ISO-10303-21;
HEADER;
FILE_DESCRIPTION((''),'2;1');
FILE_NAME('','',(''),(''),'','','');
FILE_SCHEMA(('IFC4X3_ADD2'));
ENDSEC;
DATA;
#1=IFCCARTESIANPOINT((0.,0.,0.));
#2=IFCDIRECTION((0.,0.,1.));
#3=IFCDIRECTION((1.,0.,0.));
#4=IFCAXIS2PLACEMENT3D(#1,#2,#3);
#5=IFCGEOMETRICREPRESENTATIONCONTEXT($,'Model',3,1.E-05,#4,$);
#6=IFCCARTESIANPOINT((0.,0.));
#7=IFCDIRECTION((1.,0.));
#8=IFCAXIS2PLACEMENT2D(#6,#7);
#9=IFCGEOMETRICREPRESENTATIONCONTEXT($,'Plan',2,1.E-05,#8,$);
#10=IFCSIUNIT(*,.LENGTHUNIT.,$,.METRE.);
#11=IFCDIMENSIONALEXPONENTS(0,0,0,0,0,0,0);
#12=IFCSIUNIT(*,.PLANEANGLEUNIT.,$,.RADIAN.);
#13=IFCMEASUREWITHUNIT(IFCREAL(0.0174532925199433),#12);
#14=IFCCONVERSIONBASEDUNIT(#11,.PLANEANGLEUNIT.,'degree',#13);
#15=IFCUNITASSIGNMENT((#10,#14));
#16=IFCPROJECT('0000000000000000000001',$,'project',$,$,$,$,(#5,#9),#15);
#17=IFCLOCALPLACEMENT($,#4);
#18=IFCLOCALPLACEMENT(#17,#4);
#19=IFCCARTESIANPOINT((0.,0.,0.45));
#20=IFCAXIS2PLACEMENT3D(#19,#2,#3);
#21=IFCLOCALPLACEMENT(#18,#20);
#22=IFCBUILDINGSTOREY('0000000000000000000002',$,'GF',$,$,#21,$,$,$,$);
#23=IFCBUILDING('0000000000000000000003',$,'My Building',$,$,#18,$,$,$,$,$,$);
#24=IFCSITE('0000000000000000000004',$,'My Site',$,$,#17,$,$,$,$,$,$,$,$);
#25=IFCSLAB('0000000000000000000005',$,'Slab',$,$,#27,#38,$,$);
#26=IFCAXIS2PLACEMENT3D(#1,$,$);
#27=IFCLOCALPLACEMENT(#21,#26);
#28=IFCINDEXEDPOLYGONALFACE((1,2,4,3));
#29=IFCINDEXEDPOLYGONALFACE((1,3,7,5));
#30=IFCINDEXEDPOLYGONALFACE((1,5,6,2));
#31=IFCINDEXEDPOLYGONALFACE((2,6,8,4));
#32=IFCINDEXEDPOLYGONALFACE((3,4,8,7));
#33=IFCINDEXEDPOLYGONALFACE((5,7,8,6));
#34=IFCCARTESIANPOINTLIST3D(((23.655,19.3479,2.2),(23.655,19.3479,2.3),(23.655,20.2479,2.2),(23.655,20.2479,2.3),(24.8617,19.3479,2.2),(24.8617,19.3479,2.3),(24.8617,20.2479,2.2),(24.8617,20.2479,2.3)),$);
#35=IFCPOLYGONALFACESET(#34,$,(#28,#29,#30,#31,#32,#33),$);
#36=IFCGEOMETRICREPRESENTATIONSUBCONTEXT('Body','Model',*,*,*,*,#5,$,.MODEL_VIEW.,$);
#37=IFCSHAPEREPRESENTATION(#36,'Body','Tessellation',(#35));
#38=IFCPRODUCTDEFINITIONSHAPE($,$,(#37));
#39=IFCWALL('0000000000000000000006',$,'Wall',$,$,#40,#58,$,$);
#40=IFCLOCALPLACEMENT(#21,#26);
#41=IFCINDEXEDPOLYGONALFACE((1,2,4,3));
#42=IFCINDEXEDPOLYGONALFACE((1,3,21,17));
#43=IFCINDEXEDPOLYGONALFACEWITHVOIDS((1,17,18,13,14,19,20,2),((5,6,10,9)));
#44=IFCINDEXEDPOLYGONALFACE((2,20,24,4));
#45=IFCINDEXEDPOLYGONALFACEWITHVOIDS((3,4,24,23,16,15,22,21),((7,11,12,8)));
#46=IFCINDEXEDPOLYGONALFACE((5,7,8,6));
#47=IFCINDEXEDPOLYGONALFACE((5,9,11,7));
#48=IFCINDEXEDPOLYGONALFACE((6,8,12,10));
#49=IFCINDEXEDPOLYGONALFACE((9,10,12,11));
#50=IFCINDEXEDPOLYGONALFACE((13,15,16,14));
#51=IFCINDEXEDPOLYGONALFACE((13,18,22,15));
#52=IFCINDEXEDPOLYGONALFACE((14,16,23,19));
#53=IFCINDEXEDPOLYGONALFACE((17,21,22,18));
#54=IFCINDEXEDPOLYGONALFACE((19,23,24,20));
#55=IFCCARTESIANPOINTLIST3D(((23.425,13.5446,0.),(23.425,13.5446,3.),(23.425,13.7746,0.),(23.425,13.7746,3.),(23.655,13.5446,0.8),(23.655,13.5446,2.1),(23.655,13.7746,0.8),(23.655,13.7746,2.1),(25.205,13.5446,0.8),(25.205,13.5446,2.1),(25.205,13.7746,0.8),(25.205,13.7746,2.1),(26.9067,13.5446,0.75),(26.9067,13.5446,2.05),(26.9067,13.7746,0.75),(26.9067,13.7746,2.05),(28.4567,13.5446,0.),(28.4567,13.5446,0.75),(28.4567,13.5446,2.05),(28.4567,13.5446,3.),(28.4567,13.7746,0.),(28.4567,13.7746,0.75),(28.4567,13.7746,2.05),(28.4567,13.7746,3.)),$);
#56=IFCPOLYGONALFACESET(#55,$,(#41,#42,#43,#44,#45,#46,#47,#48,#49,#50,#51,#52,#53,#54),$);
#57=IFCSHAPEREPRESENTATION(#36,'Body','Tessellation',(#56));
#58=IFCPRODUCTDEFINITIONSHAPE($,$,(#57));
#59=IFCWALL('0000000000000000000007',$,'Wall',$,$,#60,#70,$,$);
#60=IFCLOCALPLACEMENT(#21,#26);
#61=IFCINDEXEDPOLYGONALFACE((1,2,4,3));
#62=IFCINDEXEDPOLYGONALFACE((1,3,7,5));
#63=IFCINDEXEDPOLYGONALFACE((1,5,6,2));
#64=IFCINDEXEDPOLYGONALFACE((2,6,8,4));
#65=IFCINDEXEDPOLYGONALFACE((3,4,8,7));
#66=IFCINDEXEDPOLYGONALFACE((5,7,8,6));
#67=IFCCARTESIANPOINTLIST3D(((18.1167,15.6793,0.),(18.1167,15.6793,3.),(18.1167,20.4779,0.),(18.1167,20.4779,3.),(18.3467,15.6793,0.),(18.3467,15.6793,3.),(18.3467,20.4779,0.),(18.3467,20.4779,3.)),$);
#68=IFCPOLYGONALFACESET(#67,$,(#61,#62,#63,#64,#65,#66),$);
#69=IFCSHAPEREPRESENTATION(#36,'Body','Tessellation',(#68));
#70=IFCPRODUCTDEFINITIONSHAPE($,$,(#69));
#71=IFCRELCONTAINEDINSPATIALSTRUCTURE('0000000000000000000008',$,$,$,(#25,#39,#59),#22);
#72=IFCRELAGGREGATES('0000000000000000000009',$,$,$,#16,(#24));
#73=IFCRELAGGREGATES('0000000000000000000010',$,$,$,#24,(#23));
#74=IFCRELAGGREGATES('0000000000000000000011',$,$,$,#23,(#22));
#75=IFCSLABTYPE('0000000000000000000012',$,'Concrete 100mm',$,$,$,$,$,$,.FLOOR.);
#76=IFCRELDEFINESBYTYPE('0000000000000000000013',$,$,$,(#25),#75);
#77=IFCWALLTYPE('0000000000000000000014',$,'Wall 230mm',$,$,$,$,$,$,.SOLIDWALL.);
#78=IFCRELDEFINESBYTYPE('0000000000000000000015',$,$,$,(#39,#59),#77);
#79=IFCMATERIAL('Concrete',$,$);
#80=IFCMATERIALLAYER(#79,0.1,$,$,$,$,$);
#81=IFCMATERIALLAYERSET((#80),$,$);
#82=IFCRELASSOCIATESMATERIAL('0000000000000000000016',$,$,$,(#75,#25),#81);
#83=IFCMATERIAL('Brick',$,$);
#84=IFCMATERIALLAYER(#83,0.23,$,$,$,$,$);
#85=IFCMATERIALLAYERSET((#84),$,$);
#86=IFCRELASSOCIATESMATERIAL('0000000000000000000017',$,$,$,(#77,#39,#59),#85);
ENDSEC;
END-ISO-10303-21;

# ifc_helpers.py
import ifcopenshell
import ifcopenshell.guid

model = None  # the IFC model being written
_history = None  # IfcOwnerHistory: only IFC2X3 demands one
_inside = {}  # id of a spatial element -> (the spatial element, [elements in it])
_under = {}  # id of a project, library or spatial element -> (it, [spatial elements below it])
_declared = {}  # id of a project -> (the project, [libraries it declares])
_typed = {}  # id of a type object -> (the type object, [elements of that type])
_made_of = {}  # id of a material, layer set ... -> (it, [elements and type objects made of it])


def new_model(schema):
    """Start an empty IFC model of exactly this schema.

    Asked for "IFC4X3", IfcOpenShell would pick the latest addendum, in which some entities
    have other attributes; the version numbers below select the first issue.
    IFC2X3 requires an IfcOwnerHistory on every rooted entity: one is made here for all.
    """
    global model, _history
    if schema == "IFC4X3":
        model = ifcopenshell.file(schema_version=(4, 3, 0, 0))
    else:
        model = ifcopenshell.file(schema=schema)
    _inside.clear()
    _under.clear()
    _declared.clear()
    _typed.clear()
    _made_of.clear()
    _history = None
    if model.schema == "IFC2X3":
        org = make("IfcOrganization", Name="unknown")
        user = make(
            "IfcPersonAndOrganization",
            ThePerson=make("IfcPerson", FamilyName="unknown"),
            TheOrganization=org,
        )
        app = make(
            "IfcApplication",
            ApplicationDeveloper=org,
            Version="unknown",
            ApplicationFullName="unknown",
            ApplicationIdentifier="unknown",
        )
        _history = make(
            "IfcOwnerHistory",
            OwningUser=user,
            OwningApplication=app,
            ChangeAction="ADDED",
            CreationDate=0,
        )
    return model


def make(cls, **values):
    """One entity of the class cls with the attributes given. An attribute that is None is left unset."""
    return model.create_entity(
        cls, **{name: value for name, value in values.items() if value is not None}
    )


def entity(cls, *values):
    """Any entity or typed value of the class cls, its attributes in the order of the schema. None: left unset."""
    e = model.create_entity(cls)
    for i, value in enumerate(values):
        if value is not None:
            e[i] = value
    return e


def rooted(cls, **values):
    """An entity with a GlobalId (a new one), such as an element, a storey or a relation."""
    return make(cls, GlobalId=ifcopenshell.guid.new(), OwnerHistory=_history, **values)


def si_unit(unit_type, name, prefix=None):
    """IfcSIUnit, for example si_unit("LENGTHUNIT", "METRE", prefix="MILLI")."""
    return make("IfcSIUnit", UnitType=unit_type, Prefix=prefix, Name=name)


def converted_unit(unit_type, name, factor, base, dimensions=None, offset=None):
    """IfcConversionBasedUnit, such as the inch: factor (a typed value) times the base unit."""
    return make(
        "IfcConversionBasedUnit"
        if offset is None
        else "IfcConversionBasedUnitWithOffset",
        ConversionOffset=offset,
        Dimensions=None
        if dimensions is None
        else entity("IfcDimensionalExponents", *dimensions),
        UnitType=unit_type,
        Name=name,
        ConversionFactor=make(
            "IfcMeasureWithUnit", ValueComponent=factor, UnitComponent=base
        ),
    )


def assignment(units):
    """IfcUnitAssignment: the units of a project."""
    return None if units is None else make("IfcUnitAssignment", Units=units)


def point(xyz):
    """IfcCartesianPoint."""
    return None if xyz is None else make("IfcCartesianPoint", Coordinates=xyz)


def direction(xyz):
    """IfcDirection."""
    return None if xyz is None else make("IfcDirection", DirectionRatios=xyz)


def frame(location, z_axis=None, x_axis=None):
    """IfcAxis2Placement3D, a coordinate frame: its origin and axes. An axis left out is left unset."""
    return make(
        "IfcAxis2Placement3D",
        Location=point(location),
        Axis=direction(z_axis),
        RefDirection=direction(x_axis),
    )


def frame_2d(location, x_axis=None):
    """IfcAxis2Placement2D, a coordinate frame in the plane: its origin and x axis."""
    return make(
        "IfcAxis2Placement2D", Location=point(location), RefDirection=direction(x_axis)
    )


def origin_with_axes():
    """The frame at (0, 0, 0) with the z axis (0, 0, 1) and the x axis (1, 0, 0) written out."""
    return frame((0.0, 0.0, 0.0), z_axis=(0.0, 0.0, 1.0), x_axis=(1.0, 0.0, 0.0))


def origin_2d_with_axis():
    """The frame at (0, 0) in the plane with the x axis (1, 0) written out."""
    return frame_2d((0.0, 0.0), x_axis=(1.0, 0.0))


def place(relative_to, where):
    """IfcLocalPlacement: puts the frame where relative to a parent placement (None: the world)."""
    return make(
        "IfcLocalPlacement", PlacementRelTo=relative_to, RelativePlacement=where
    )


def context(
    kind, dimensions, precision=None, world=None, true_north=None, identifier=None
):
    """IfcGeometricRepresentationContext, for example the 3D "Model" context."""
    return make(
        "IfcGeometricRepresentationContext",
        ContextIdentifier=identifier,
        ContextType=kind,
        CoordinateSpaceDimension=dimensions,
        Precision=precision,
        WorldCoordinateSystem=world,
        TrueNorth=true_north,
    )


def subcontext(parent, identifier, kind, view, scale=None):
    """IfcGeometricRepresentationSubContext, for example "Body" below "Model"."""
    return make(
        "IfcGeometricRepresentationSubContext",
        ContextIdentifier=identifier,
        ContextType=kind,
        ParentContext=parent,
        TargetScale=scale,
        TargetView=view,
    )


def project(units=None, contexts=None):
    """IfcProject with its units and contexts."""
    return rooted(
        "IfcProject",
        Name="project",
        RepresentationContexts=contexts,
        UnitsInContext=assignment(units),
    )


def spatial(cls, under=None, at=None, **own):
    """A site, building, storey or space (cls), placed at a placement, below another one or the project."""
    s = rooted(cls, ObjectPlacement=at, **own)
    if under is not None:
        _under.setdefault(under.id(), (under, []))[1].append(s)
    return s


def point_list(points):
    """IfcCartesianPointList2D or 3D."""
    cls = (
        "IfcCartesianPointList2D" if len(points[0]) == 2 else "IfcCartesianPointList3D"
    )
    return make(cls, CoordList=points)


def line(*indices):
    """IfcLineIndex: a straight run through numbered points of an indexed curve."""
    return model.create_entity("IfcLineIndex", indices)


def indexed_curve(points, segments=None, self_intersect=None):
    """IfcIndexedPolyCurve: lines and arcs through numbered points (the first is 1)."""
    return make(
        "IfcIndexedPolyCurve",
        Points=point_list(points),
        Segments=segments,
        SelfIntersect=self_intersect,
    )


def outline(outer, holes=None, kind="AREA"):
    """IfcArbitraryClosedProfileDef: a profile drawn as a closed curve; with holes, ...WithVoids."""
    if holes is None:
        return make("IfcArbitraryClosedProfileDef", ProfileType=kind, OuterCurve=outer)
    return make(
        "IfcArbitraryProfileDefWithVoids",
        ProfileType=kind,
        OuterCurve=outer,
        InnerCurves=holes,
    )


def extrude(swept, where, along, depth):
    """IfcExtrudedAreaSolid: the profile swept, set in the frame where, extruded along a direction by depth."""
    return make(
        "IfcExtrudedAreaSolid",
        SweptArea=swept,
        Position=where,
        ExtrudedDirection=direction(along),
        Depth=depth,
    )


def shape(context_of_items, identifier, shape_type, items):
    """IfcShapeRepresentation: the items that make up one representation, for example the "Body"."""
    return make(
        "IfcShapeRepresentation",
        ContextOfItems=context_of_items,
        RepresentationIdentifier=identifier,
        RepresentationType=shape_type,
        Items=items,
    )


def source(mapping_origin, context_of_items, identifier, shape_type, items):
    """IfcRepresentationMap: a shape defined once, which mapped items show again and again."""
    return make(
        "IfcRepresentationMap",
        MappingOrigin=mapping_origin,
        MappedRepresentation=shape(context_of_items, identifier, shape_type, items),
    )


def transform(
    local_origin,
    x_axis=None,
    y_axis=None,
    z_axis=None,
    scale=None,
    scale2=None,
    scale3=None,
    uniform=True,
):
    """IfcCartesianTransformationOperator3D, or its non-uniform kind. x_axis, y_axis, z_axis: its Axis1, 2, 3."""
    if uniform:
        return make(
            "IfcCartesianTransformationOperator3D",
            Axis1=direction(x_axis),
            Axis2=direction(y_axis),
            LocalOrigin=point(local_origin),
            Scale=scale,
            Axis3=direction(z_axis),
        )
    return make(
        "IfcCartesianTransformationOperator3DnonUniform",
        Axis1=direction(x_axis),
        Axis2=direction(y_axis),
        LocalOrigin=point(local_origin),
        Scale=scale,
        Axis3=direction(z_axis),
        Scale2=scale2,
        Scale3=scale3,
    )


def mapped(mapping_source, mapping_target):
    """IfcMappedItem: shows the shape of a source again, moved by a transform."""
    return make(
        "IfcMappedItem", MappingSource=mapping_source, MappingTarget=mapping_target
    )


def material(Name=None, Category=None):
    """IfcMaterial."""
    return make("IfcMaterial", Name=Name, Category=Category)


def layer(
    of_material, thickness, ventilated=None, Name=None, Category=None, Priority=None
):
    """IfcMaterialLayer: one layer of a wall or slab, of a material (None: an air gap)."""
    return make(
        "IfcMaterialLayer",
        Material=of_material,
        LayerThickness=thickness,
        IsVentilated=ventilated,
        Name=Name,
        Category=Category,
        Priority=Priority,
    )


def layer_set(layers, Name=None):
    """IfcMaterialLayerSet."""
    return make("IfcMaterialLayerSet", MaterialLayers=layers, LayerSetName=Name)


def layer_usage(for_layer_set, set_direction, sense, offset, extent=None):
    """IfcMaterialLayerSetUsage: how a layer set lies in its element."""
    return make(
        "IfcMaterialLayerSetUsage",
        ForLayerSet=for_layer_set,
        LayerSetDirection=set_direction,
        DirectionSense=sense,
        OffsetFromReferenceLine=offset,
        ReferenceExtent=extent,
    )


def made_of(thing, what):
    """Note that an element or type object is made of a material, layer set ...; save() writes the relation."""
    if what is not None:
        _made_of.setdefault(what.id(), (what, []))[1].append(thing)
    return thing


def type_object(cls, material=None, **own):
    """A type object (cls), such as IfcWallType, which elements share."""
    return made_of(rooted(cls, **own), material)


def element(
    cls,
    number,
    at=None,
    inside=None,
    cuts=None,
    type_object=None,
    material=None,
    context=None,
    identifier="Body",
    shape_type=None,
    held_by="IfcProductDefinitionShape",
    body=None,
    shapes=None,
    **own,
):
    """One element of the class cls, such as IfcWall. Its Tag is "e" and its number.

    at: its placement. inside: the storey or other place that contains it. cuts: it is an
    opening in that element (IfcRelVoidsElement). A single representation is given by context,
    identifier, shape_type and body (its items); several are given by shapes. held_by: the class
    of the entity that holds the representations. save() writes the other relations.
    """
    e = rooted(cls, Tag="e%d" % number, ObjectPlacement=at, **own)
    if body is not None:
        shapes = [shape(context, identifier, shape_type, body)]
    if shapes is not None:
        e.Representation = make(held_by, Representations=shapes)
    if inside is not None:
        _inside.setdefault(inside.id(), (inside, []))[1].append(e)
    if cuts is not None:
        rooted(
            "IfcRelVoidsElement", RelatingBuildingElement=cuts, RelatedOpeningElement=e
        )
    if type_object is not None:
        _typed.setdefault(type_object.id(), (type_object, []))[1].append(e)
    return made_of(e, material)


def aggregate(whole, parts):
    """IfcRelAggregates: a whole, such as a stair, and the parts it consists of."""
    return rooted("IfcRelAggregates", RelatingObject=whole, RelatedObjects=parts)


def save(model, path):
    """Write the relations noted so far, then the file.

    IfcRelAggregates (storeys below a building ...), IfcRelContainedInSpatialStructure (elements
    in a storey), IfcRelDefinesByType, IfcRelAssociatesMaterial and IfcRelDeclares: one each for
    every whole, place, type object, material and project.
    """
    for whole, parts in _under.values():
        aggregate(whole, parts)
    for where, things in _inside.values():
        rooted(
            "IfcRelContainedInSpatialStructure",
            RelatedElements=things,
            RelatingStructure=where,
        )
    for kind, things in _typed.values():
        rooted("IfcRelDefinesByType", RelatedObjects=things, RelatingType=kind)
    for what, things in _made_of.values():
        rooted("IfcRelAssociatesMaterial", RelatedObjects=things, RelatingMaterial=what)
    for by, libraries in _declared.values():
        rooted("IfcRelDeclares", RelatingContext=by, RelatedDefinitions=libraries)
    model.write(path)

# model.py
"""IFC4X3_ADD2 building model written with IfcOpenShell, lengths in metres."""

from ifc_helpers import new_model, entity, si_unit, converted_unit, frame, origin_with_axes, origin_2d_with_axis, place, context, subcontext, project, spatial, line, indexed_curve, outline, extrude, source, transform, mapped, material, layer, layer_set, layer_usage, type_object, element, save


model = new_model("IFC4X3_ADD2")

# Units and contexts
model_context = context("Model", 3, precision=1e-05, world=origin_with_axes())
plan_context = context("Plan", 2, precision=1e-05, world=origin_2d_with_axis())
body_context_1 = subcontext(model_context, "Body", "Model", "MODEL_VIEW")
ifc_project = project(units=[si_unit("LENGTHUNIT", "METRE"), converted_unit("PLANEANGLEUNIT", "degree", entity("IfcReal", 0.0174532925199433), si_unit("PLANEANGLEUNIT", "RADIAN"), dimensions=[0, 0, 0, 0, 0, 0, 0])], contexts=[model_context, plan_context])

# Site, building, storey
site_placement = place(None, origin_with_axes())
site = spatial("IfcSite", under=ifc_project, at=site_placement, Name="My Site")
building_placement = place(site_placement, origin_with_axes())
building = spatial("IfcBuilding", under=site, at=building_placement, Name="My Building")
storey_placement = place(building_placement, frame((0.0, 0.0, 0.45), z_axis=(0.0, 0.0, 1.0), x_axis=(1.0, 0.0, 0.0)))
storey = spatial("IfcBuildingStorey", under=building, at=storey_placement, Name="GF")

# Slab
ifc_material_1 = material(Name="Concrete")
ifc_layer_1 = layer(ifc_material_1, 0.1)
ifc_layer_set_1 = layer_set([ifc_layer_1])
ifc_layer_usage_1 = layer_usage(ifc_layer_set_1, "AXIS3", "POSITIVE", 0.0)
slab_type = type_object("IfcSlabType", Name="Concrete 100mm", PredefinedType="FLOOR", material=ifc_layer_set_1)
slab_placement = place(storey_placement, frame((23.655, 19.3479, 2.2), z_axis=(0.0, 0.0, 1.0), x_axis=(1.0, 0.0, 0.0)))
element("IfcSlab", 1, at=slab_placement, inside=storey, type_object=slab_type, material=ifc_layer_usage_1, Name="Slab", context=body_context_1, shape_type="SweptSolid", body=[
    extrude(outline(indexed_curve([(0.0, 0.0), (1.2066, 0.0), (1.2066, 0.9), (0.0, 0.9), (0.0, 0.0)])), None, (0.0, 0.0, 1.0), 0.1),
])

# Wall, openings
ifc_material_2 = material(Name="Brick")
ifc_layer_2 = layer(ifc_material_2, 0.23)
ifc_layer_set_2 = layer_set([ifc_layer_2])
wall_type_1 = type_object("IfcWallType", Name="Wall 230mm", PredefinedType="SOLIDWALL", material=ifc_layer_set_2)
ifc_layer_usage_2 = layer_usage(ifc_layer_set_2, "AXIS2", "POSITIVE", 0.0)
wall_1_placement = place(storey_placement, frame((23.425, 13.5446, 0.0), z_axis=(0.0, 0.0, 1.0), x_axis=(1.0, 0.0, 0.0)))
wall_1 = element("IfcWall", 2, at=wall_1_placement, inside=storey, type_object=wall_type_1, material=ifc_layer_usage_2, Name="Wall", context=body_context_1, shape_type="SweptSolid", body=[
    extrude(outline(indexed_curve([(0.0, 0.0), (0.0, 0.23), (5.0317, 0.23), (5.0317, 0.0), (0.0, 0.0)], self_intersect=False)), origin_with_axes(), (0.0, 0.0, 1.0), 3.0),
])
shared_shape_1 = source(origin_with_axes(), body_context_1, "Body", "SweptSolid", [
    extrude(outline(indexed_curve([(0.0, 0.0), (1.55, 0.0), (1.55, 1.3), (0.0, 1.3)], segments=[line(1, 2, 3, 4, 1)])), frame((-0.775, -0.6, 0.0), z_axis=(0.0, -1.0, 0.0), x_axis=(1.0, 0.0, 0.0)), (0.0, 0.0, -1.0), 1.2),
])
opening_1_placement = place(wall_1_placement, frame((1.005, 0.0, 0.8), z_axis=(0.0, 0.0, 1.0), x_axis=(1.0, 0.0, 0.0)))
element("IfcOpeningElement", 3, at=opening_1_placement, cuts=wall_1, PredefinedType="OPENING", context=body_context_1, shape_type="MappedRepresentation", body=[
    mapped(shared_shape_1, transform((0.0, 0.0, 0.0), x_axis=(1.0, 0.0, 0.0), y_axis=(0.0, 1.0, 0.0), z_axis=(0.0, 0.0, 1.0), scale=1.0)),
])
opening_2_placement = place(wall_1_placement, frame((4.2567, 0.0, 0.75), z_axis=(0.0, 0.0, 1.0), x_axis=(1.0, 0.0, 0.0)))
element("IfcOpeningElement", 4, at=opening_2_placement, cuts=wall_1, PredefinedType="OPENING", context=body_context_1, shape_type="MappedRepresentation", body=[
    mapped(shared_shape_1, transform((0.0, 0.0, 0.0), x_axis=(1.0, 0.0, 0.0), y_axis=(0.0, 1.0, 0.0), z_axis=(0.0, 0.0, 1.0), scale=1.0)),
])

# Wall
ifc_layer_usage_3 = layer_usage(ifc_layer_set_2, "AXIS2", "POSITIVE", 0.0)
wall_2_placement = place(storey_placement, frame((18.3467, 15.6793, 0.0), z_axis=(0.0, 0.0, 1.0), x_axis=(0.0, 1.0, 0.0)))
element("IfcWall", 5, at=wall_2_placement, inside=storey, type_object=wall_type_1, material=ifc_layer_usage_3, Name="Wall", context=body_context_1, shape_type="SweptSolid", body=[
    extrude(outline(indexed_curve([(0.0, 0.0), (0.0, 0.23), (4.7985, 0.23), (4.7985, 0.0), (0.0, 0.0)], self_intersect=False)), origin_with_axes(), (0.0, 0.0, 1.0), 3.0),
])

save(model, "model.ifc")
